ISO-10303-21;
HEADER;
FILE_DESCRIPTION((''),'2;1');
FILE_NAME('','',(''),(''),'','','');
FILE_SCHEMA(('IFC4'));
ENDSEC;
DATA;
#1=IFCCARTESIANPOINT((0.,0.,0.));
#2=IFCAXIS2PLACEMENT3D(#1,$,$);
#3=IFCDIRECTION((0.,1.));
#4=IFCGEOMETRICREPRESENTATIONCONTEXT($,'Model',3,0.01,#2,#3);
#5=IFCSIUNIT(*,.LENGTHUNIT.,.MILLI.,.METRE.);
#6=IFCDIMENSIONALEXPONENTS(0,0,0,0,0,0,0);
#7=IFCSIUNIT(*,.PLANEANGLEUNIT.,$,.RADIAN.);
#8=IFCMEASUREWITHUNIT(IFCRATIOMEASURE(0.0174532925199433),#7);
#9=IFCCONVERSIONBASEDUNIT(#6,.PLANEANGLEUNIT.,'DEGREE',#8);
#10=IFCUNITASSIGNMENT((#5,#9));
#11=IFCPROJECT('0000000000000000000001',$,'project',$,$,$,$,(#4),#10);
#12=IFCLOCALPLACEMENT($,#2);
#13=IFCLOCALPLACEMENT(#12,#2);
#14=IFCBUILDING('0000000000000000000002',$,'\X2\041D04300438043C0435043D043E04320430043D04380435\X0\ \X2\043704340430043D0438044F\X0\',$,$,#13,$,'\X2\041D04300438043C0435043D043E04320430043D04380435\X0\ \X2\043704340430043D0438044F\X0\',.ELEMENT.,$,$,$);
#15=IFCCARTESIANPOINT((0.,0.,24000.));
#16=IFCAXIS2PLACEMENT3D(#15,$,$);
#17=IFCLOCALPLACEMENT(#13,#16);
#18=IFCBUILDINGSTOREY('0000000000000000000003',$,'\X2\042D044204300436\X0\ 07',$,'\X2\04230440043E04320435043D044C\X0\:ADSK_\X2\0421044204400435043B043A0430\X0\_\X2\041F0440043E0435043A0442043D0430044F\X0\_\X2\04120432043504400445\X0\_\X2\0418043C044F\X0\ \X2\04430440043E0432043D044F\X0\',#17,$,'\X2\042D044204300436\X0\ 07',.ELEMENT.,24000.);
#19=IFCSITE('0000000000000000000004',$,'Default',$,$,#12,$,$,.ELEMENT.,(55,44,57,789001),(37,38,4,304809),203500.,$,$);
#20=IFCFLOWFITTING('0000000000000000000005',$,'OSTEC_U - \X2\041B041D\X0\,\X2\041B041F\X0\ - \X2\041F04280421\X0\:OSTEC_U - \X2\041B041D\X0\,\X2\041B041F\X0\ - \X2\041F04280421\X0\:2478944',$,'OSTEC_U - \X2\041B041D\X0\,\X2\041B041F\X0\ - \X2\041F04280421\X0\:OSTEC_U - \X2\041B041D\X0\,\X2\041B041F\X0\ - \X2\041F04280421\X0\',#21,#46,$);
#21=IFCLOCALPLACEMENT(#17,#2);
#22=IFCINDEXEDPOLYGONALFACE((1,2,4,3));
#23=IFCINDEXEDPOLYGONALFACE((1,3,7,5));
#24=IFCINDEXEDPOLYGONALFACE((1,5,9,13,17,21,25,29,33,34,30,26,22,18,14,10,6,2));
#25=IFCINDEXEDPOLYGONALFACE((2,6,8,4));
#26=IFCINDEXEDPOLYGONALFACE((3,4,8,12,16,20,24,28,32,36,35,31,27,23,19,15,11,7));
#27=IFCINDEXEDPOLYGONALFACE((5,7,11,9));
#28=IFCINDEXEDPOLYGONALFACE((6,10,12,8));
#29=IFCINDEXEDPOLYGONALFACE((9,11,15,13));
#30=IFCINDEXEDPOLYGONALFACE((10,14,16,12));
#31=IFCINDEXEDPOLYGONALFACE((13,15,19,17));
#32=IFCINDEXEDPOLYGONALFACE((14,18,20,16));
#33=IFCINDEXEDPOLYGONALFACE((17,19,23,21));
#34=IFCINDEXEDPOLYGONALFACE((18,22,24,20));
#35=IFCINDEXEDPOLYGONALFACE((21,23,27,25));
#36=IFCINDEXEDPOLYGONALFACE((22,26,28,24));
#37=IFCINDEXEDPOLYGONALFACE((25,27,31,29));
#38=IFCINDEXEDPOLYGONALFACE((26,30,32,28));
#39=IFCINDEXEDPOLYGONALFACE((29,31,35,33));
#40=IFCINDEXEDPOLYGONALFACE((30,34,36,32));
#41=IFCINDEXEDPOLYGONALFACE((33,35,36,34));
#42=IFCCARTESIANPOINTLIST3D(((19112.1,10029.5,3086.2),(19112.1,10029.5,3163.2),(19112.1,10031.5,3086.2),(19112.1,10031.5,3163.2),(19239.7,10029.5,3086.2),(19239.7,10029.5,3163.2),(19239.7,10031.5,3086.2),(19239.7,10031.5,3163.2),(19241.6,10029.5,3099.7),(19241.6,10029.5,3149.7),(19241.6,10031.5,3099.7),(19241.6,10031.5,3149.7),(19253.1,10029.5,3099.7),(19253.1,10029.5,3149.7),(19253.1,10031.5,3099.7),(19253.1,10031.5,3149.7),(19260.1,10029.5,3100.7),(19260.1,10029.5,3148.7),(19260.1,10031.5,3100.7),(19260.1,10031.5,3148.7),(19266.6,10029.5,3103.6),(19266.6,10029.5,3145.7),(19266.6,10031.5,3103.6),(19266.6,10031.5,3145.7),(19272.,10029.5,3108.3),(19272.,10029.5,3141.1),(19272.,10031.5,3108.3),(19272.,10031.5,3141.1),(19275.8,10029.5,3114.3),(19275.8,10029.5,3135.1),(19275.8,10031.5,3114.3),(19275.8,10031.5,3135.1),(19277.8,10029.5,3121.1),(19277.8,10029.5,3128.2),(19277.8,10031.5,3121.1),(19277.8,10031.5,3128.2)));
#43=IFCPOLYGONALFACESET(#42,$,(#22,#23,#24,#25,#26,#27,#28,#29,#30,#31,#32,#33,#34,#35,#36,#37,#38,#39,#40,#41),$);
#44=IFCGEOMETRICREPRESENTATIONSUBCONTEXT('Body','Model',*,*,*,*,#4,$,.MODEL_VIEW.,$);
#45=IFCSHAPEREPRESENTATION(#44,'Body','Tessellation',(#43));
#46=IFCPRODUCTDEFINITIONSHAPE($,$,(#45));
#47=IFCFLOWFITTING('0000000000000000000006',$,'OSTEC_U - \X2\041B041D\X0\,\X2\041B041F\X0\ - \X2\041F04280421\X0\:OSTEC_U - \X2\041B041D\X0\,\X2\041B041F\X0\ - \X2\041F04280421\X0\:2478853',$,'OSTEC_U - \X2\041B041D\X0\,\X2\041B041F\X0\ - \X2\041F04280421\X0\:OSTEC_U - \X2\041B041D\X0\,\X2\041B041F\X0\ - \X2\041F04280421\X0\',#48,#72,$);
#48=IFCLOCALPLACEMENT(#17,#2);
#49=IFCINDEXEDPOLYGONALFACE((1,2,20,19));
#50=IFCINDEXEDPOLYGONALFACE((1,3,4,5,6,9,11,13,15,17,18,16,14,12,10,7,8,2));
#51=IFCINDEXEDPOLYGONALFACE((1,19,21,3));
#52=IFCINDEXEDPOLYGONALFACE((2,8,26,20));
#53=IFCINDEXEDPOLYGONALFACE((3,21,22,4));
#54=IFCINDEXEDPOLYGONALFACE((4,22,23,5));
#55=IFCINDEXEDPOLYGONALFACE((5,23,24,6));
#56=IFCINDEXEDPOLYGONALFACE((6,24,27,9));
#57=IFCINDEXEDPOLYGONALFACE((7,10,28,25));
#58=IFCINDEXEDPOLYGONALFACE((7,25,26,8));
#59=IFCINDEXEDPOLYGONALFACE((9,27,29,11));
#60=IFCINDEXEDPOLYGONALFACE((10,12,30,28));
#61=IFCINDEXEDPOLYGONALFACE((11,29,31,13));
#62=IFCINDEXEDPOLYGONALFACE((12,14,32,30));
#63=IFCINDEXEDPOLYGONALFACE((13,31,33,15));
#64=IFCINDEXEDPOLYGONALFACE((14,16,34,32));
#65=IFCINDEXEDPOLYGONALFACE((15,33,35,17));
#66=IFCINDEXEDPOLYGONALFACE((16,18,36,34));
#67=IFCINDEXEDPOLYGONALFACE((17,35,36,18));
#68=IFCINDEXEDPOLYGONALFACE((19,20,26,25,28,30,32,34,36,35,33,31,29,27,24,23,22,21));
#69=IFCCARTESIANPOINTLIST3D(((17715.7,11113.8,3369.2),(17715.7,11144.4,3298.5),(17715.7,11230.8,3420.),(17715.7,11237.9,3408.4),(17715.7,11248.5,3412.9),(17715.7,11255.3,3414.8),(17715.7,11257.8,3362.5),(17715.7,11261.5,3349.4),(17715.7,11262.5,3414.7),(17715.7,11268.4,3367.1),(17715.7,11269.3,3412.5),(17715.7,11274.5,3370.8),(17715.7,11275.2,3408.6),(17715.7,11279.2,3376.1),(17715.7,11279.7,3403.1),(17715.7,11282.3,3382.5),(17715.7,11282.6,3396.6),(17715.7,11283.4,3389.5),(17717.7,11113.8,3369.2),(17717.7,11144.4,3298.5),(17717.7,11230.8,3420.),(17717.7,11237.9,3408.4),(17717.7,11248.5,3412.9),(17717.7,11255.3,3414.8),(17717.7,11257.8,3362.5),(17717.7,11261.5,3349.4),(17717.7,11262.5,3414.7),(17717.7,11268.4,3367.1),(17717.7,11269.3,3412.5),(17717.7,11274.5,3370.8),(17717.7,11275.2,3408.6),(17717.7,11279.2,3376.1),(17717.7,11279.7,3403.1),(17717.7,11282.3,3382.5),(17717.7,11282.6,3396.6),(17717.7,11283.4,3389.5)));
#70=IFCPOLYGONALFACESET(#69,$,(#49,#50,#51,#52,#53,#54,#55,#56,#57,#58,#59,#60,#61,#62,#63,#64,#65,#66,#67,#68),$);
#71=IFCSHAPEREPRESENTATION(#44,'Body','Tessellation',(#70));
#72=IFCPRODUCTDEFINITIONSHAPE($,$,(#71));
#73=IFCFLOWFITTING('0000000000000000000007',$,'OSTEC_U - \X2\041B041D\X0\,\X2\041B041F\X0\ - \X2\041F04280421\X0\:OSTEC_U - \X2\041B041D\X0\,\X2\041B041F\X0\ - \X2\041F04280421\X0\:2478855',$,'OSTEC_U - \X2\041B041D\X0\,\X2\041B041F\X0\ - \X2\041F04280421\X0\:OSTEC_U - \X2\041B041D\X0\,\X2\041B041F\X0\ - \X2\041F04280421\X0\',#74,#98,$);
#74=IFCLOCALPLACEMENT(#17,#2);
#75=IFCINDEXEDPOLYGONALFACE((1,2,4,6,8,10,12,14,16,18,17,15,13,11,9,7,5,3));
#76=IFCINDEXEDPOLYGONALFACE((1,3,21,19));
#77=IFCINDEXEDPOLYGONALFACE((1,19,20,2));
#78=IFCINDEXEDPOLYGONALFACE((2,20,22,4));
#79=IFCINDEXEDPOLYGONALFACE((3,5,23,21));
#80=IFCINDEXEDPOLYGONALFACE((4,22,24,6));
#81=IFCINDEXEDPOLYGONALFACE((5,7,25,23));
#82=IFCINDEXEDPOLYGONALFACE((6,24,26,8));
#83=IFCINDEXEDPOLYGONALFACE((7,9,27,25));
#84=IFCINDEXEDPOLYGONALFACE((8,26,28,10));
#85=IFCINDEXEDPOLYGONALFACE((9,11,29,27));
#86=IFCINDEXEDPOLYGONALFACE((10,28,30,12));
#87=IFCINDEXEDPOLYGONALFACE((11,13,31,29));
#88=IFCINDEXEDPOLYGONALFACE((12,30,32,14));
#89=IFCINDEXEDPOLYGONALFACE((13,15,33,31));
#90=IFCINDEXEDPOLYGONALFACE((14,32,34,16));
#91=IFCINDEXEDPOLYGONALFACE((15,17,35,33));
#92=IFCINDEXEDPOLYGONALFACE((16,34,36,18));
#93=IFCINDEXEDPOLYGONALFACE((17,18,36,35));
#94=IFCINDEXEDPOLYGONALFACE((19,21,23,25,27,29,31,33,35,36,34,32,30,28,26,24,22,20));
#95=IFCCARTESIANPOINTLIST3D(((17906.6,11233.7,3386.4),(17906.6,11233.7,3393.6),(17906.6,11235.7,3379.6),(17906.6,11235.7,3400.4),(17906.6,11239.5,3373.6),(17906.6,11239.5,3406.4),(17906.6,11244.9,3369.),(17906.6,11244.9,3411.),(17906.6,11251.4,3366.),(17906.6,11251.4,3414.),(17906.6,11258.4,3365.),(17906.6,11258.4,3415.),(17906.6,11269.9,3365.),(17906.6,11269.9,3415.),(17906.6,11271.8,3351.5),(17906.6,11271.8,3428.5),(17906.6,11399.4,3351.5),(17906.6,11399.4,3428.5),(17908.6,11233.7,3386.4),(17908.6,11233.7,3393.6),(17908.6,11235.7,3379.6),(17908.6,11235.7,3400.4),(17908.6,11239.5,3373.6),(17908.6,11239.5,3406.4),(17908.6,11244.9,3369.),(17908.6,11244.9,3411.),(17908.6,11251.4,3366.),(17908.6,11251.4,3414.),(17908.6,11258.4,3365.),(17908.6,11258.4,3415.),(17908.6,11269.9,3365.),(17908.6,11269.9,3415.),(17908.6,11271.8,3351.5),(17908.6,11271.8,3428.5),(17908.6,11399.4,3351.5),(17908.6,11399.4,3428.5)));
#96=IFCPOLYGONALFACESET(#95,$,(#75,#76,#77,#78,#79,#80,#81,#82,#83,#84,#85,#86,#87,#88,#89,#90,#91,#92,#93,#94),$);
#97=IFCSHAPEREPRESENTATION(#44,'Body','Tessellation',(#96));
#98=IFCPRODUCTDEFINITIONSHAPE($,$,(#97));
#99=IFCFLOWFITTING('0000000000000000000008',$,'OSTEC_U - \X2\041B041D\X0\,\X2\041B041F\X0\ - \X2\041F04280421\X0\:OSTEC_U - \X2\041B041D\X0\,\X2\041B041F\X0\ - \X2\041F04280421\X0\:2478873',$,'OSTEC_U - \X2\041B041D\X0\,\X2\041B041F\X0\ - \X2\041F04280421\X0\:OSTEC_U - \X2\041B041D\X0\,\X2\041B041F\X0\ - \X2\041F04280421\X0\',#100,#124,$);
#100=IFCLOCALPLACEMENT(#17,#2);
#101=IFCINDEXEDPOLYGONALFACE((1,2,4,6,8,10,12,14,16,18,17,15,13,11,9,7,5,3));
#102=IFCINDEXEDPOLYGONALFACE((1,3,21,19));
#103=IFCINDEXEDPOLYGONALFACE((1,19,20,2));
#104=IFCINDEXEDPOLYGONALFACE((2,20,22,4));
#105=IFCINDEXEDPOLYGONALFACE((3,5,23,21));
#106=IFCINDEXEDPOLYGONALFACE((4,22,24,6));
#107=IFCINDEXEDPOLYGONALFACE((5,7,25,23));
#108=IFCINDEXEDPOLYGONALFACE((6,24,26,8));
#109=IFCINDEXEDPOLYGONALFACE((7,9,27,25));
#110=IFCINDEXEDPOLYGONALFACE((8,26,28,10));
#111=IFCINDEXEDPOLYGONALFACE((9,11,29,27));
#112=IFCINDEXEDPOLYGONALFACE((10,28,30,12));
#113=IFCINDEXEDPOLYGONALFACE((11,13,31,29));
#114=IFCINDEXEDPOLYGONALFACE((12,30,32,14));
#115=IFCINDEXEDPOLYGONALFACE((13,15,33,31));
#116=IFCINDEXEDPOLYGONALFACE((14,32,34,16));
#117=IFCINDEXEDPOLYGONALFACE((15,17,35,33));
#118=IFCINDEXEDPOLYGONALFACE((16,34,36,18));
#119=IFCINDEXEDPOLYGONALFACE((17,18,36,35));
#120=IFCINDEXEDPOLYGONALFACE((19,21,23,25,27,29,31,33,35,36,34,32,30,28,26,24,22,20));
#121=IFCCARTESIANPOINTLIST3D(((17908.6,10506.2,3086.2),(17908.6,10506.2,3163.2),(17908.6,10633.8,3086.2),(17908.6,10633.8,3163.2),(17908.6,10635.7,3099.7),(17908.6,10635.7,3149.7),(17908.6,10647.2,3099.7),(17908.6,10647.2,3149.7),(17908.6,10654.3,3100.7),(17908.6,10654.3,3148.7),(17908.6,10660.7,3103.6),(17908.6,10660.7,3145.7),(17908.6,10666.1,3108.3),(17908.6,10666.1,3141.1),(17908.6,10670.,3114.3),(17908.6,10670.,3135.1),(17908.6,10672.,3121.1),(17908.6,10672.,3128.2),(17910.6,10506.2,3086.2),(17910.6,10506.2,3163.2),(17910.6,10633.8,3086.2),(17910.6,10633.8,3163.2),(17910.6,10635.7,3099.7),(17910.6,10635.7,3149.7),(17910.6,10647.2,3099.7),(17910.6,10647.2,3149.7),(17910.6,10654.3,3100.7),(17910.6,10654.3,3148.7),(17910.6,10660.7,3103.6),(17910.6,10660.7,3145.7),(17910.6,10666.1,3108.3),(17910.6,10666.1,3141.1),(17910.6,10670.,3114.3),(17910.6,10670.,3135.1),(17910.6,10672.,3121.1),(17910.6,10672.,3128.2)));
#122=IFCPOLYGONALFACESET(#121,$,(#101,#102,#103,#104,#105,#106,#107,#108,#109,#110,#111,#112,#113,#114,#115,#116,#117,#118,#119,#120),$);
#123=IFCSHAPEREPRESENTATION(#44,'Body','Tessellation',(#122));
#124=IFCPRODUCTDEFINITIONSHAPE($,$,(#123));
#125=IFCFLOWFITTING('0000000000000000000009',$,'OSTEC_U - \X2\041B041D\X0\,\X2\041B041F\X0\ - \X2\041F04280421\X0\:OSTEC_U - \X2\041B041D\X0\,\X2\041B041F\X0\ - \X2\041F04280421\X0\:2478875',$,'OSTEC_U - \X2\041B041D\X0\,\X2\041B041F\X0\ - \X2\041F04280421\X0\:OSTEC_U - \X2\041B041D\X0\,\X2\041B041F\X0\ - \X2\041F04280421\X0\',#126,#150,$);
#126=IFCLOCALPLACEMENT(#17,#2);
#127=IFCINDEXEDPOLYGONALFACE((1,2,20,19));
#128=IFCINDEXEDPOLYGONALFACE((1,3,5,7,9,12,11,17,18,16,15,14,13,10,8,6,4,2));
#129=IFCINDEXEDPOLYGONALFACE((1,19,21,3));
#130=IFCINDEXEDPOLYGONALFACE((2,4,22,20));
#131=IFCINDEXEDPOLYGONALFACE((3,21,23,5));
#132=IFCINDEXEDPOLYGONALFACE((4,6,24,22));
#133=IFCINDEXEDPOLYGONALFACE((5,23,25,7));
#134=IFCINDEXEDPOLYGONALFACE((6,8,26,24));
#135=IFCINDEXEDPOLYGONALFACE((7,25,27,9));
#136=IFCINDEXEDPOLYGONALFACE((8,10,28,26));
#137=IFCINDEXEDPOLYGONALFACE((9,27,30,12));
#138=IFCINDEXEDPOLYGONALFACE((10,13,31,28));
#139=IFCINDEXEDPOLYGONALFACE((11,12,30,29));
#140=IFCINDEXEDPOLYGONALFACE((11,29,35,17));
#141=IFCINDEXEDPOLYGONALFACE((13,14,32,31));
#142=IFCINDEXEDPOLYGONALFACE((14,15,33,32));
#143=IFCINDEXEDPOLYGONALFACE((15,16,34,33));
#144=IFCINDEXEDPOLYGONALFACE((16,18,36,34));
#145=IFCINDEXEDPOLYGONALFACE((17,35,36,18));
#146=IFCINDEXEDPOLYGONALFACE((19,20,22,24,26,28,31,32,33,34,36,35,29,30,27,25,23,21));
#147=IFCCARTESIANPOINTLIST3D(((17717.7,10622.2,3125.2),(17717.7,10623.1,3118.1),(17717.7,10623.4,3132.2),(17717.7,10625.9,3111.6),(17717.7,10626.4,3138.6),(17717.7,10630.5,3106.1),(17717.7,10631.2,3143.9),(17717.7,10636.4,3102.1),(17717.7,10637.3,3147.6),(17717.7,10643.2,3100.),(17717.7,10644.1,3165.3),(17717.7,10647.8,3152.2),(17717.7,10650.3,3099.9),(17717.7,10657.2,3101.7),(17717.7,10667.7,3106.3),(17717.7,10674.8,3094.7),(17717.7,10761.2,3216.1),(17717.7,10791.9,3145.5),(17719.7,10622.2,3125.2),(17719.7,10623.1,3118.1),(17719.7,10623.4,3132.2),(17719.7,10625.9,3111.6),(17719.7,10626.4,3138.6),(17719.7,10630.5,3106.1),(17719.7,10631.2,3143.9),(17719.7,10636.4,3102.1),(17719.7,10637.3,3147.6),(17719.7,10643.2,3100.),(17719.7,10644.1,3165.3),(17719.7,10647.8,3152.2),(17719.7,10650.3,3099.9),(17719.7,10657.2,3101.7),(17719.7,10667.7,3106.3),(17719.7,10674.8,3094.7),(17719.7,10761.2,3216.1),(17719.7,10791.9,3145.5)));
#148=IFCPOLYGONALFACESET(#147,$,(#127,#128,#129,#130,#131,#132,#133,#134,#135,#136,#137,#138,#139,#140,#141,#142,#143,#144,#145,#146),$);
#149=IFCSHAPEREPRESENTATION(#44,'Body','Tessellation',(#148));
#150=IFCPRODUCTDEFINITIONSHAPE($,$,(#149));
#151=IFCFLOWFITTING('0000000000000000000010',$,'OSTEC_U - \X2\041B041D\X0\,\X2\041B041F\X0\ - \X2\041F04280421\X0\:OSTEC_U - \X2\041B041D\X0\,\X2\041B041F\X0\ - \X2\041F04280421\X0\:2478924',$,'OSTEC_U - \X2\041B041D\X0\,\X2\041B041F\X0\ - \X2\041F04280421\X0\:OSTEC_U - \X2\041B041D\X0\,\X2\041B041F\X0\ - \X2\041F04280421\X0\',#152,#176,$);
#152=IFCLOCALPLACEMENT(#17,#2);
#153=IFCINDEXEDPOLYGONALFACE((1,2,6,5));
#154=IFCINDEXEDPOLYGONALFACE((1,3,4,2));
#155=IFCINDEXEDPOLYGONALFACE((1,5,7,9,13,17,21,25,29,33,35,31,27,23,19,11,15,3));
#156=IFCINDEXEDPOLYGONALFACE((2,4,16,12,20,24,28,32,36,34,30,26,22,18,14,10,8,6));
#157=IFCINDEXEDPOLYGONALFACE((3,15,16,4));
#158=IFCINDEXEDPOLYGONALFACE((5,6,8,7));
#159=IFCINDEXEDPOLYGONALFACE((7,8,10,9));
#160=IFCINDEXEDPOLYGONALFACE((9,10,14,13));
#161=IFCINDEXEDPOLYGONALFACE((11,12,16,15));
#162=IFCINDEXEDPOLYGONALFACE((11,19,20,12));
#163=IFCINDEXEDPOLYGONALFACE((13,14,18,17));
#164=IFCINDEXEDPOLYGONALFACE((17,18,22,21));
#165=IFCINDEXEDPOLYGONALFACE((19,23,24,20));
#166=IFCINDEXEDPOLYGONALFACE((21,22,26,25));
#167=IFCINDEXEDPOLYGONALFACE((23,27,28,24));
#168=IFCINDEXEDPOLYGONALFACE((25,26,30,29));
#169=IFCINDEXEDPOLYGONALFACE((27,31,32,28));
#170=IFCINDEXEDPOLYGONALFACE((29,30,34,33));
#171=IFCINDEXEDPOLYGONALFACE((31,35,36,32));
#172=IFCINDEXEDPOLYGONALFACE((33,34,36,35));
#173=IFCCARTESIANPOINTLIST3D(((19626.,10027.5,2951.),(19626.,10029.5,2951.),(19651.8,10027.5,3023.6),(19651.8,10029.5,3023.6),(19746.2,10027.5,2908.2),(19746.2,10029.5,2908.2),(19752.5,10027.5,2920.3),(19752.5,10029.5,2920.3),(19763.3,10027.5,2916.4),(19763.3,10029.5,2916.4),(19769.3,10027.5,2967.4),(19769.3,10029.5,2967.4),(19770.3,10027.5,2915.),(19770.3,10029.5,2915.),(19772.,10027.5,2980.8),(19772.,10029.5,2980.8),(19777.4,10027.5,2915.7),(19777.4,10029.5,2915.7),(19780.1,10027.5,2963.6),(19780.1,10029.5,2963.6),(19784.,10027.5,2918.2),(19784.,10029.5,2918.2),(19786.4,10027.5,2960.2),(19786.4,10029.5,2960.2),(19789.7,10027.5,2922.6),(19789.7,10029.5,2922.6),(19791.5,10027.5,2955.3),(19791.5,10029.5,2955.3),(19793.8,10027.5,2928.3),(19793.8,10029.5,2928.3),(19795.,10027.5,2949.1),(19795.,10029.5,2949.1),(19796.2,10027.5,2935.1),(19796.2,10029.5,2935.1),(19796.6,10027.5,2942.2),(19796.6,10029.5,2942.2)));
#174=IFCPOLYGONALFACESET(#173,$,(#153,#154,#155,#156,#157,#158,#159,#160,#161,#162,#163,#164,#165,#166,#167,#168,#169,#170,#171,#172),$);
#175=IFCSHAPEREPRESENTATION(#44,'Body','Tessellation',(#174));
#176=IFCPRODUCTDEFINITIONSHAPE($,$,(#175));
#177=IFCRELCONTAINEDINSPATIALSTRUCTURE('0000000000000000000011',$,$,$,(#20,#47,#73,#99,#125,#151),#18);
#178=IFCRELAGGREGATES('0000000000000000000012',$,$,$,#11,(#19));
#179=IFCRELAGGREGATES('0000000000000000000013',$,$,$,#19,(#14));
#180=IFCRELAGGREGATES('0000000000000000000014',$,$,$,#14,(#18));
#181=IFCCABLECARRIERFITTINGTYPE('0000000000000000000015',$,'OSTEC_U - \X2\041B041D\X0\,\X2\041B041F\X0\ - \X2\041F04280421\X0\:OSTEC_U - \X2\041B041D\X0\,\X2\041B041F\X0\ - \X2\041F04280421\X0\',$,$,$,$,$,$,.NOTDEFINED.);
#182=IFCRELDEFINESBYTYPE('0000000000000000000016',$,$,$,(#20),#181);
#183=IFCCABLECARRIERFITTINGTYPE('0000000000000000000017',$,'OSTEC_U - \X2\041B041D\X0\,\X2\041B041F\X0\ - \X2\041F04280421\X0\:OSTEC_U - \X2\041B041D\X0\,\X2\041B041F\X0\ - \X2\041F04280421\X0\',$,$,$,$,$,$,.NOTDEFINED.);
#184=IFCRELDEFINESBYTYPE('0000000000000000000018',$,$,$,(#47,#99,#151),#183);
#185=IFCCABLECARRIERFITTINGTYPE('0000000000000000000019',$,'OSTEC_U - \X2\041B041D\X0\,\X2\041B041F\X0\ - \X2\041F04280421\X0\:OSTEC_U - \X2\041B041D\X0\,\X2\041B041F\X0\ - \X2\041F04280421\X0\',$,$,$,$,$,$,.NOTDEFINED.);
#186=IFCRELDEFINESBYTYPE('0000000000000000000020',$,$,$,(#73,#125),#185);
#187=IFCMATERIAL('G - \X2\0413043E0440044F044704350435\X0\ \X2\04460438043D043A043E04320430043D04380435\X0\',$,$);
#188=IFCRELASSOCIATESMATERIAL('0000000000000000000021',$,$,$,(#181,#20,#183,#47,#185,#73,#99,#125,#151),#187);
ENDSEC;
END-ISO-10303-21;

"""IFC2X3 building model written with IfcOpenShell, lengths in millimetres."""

from ifc_helpers import new_model, entity, si_unit, converted_unit, direction, frame, frame_2d, origin, place, context, subcontext, project, spatial, polyline, circle_curve, parameter, trimmed, segment, composite_curve, outline, extrude, source, transform, mapped, material, type_object, type_shapes, element, save


model = new_model("IFC2X3")

# Units and contexts
model_context = context("Model", 3, precision=0.01, world=origin(), true_north=direction((0.0, 1.0)))
body_context = subcontext(model_context, "Body", "Model", "MODEL_VIEW")
ifc_project = project(units=[si_unit("LENGTHUNIT", "METRE", prefix="MILLI"), converted_unit("PLANEANGLEUNIT", "DEGREE", entity("IfcRatioMeasure", 0.0174532925199433), si_unit("PLANEANGLEUNIT", "RADIAN"), dimensions=[0, 0, 0, 0, 0, 0, 0])], contexts=[model_context])

# Site, building, storey
site_placement = place(None, origin())
site = spatial("IfcSite", under=ifc_project, at=site_placement, Name="Default", CompositionType="ELEMENT", RefLatitude=(55, 44, 57, 789001), RefLongitude=(37, 38, 4, 304809), RefElevation=203500.0)
building_placement = place(site_placement, origin())
building = spatial("IfcBuilding", under=site, at=building_placement, Name="Наименование здания", LongName="Наименование здания", CompositionType="ELEMENT")
storey_placement = place(building_placement, frame((0.0, 0.0, 24000.0)))
storey = spatial("IfcBuildingStorey", under=building, at=storey_placement, Name="Этаж 07", ObjectType="Уровень:ADSK_Стрелка_Проектная_Вверх_Имя уровня", LongName="Этаж 07", CompositionType="ELEMENT", Elevation=24000.0)

# Flow fittings
ifc_material = material(Name="G - Горячее цинкование")
shared_shape_1 = source(origin(), body_context, "Body", "SweptSolid", [
    extrude(outline(composite_curve([segment(trimmed(circle_curve(frame_2d((-41.5, 0.0), x_axis=(1.0, 0.0)), 25.0), [parameter(90.0)], [parameter(270.0)], True, "PARAMETER"), True, "CONTINUOUS"), segment(polyline([(-41.5, -25.0), (-30.0, -25.0)]), True, "CONTINUOUS"), segment(polyline([(-30.0, -25.0), (-28.1, -38.5)]), True, "CONTINUOUS"), segment(polyline([(-28.1, -38.5), (99.5, -38.5)]), True, "CONTINUOUS"), segment(polyline([(99.5, -38.5), (99.5, 38.5)]), True, "CONTINUOUS"), segment(polyline([(99.5, 38.5), (-28.1, 38.5)]), True, "CONTINUOUS"), segment(polyline([(-28.1, 38.5), (-30.0, 25.0)]), True, "CONTINUOUS"), segment(polyline([(-30.0, 25.0), (-41.5, 25.0)]), True, "CONTINUOUS")], self_intersect=False)), frame((41.5, 0.0, 0.0), z_axis=(0.0, 0.0, -1.0), x_axis=(1.0, 0.0, 0.0)), (0.0, 0.0, -1.0), 2.0),
])
cable_carrier_fitting_type_1 = type_object("IfcCableCarrierFittingType", Name="OSTEC_U - ЛН,ЛП - ПШС:OSTEC_U - ЛН,ЛП - ПШС", PredefinedType="NOTDEFINED", material=ifc_material)
type_shapes(cable_carrier_fitting_type_1, [shared_shape_1])
flow_fitting_1_placement = place(storey_placement, frame((19253.1, 10031.5, 3124.7), z_axis=(0.0, -1.0, 0.0), x_axis=(-1.0, 0.0, 0.0)))
element("IfcFlowFitting", 1, at=flow_fitting_1_placement, inside=storey, type_object=cable_carrier_fitting_type_1, material=ifc_material, Name="OSTEC_U - ЛН,ЛП - ПШС:OSTEC_U - ЛН,ЛП - ПШС:2478944", ObjectType="OSTEC_U - ЛН,ЛП - ПШС:OSTEC_U - ЛН,ЛП - ПШС", context=body_context, shape_type="MappedRepresentation", body=[
    mapped(shared_shape_1, transform((0.0, 0.0, 0.0), scale=1.0)),
])
cable_carrier_fitting_type_2 = type_object("IfcCableCarrierFittingType", Name="OSTEC_U - ЛН,ЛП - ПШС:OSTEC_U - ЛН,ЛП - ПШС", PredefinedType="NOTDEFINED", material=ifc_material)
shared_shape_2 = source(origin(), body_context, "Body", "SweptSolid", [
    extrude(outline(composite_curve([segment(trimmed(circle_curve(frame_2d((-41.5, 0.0), x_axis=(1.0, 0.0)), 25.0), [parameter(90.0)], [parameter(270.0)], True, "PARAMETER"), True, "CONTINUOUS"), segment(polyline([(-41.5, -25.0), (-30.0, -25.0)]), True, "CONTINUOUS"), segment(polyline([(-30.0, -25.0), (-28.1, -38.5)]), True, "CONTINUOUS"), segment(polyline([(-28.1, -38.5), (99.5, -38.5)]), True, "CONTINUOUS"), segment(polyline([(99.5, -38.5), (99.5, 38.5)]), True, "CONTINUOUS"), segment(polyline([(99.5, 38.5), (-28.1, 38.5)]), True, "CONTINUOUS"), segment(polyline([(-28.1, 38.5), (-30.0, 25.0)]), True, "CONTINUOUS"), segment(polyline([(-30.0, 25.0), (-41.5, 25.0)]), True, "CONTINUOUS")], self_intersect=False)), frame((41.5, 0.0, 0.0)), (0.0, 0.0, 1.0), 2.0),
])
type_shapes(cable_carrier_fitting_type_2, [shared_shape_2])
flow_fitting_2_placement = place(storey_placement, frame((17717.7, 11258.4, 3390.0), z_axis=(-1.0, 0.0, 0.0), x_axis=(0.0, -0.917307, -0.398181)))
element("IfcFlowFitting", 2, at=flow_fitting_2_placement, inside=storey, type_object=cable_carrier_fitting_type_2, material=ifc_material, Name="OSTEC_U - ЛН,ЛП - ПШС:OSTEC_U - ЛН,ЛП - ПШС:2478853", ObjectType="OSTEC_U - ЛН,ЛП - ПШС:OSTEC_U - ЛН,ЛП - ПШС", context=body_context, shape_type="MappedRepresentation", body=[
    mapped(shared_shape_2, transform((0.0, 0.0, 0.0), scale=1.0)),
])
cable_carrier_fitting_type_3 = type_object("IfcCableCarrierFittingType", Name="OSTEC_U - ЛН,ЛП - ПШС:OSTEC_U - ЛН,ЛП - ПШС", PredefinedType="NOTDEFINED", material=ifc_material)
type_shapes(cable_carrier_fitting_type_3, [shared_shape_2])
flow_fitting_3_placement = place(storey_placement, frame((17906.6, 11258.4, 3390.0), z_axis=(1.0, 0.0, 0.0), x_axis=(0.0, 1.0, 0.0)))
element("IfcFlowFitting", 3, at=flow_fitting_3_placement, inside=storey, type_object=cable_carrier_fitting_type_3, material=ifc_material, Name="OSTEC_U - ЛН,ЛП - ПШС:OSTEC_U - ЛН,ЛП - ПШС:2478855", ObjectType="OSTEC_U - ЛН,ЛП - ПШС:OSTEC_U - ЛН,ЛП - ПШС", context=body_context, shape_type="MappedRepresentation", body=[
    mapped(shared_shape_2, transform((0.0, 0.0, 0.0), scale=1.0)),
])
flow_fitting_4_placement = place(storey_placement, frame((17908.6, 10647.2, 3124.7), z_axis=(1.0, 0.0, 0.0), x_axis=(0.0, -1.0, 0.0)))
element("IfcFlowFitting", 4, at=flow_fitting_4_placement, inside=storey, type_object=cable_carrier_fitting_type_2, material=ifc_material, Name="OSTEC_U - ЛН,ЛП - ПШС:OSTEC_U - ЛН,ЛП - ПШС:2478873", ObjectType="OSTEC_U - ЛН,ЛП - ПШС:OSTEC_U - ЛН,ЛП - ПШС", context=body_context, shape_type="MappedRepresentation", body=[
    mapped(shared_shape_2, transform((0.0, 0.0, 0.0), scale=1.0)),
])
flow_fitting_5_placement = place(storey_placement, frame((17719.7, 10647.2, 3124.7), z_axis=(-1.0, 0.0, 0.0), x_axis=(0.0, 0.917307, 0.398181)))
element("IfcFlowFitting", 5, at=flow_fitting_5_placement, inside=storey, type_object=cable_carrier_fitting_type_3, material=ifc_material, Name="OSTEC_U - ЛН,ЛП - ПШС:OSTEC_U - ЛН,ЛП - ПШС:2478875", ObjectType="OSTEC_U - ЛН,ЛП - ПШС:OSTEC_U - ЛН,ЛП - ПШС", context=body_context, shape_type="MappedRepresentation", body=[
    mapped(shared_shape_2, transform((0.0, 0.0, 0.0), scale=1.0)),
])
flow_fitting_6_placement = place(storey_placement, frame((19771.7, 10029.5, 2940.0), z_axis=(0.0, -1.0, 0.0), x_axis=(-0.942059, 0.0, 0.335447)))
element("IfcFlowFitting", 6, at=flow_fitting_6_placement, inside=storey, type_object=cable_carrier_fitting_type_2, material=ifc_material, Name="OSTEC_U - ЛН,ЛП - ПШС:OSTEC_U - ЛН,ЛП - ПШС:2478924", ObjectType="OSTEC_U - ЛН,ЛП - ПШС:OSTEC_U - ЛН,ЛП - ПШС", context=body_context, shape_type="MappedRepresentation", body=[
    mapped(shared_shape_2, transform((0.0, 0.0, 0.0), scale=1.0)),
])

save(model, "model.ifc")
